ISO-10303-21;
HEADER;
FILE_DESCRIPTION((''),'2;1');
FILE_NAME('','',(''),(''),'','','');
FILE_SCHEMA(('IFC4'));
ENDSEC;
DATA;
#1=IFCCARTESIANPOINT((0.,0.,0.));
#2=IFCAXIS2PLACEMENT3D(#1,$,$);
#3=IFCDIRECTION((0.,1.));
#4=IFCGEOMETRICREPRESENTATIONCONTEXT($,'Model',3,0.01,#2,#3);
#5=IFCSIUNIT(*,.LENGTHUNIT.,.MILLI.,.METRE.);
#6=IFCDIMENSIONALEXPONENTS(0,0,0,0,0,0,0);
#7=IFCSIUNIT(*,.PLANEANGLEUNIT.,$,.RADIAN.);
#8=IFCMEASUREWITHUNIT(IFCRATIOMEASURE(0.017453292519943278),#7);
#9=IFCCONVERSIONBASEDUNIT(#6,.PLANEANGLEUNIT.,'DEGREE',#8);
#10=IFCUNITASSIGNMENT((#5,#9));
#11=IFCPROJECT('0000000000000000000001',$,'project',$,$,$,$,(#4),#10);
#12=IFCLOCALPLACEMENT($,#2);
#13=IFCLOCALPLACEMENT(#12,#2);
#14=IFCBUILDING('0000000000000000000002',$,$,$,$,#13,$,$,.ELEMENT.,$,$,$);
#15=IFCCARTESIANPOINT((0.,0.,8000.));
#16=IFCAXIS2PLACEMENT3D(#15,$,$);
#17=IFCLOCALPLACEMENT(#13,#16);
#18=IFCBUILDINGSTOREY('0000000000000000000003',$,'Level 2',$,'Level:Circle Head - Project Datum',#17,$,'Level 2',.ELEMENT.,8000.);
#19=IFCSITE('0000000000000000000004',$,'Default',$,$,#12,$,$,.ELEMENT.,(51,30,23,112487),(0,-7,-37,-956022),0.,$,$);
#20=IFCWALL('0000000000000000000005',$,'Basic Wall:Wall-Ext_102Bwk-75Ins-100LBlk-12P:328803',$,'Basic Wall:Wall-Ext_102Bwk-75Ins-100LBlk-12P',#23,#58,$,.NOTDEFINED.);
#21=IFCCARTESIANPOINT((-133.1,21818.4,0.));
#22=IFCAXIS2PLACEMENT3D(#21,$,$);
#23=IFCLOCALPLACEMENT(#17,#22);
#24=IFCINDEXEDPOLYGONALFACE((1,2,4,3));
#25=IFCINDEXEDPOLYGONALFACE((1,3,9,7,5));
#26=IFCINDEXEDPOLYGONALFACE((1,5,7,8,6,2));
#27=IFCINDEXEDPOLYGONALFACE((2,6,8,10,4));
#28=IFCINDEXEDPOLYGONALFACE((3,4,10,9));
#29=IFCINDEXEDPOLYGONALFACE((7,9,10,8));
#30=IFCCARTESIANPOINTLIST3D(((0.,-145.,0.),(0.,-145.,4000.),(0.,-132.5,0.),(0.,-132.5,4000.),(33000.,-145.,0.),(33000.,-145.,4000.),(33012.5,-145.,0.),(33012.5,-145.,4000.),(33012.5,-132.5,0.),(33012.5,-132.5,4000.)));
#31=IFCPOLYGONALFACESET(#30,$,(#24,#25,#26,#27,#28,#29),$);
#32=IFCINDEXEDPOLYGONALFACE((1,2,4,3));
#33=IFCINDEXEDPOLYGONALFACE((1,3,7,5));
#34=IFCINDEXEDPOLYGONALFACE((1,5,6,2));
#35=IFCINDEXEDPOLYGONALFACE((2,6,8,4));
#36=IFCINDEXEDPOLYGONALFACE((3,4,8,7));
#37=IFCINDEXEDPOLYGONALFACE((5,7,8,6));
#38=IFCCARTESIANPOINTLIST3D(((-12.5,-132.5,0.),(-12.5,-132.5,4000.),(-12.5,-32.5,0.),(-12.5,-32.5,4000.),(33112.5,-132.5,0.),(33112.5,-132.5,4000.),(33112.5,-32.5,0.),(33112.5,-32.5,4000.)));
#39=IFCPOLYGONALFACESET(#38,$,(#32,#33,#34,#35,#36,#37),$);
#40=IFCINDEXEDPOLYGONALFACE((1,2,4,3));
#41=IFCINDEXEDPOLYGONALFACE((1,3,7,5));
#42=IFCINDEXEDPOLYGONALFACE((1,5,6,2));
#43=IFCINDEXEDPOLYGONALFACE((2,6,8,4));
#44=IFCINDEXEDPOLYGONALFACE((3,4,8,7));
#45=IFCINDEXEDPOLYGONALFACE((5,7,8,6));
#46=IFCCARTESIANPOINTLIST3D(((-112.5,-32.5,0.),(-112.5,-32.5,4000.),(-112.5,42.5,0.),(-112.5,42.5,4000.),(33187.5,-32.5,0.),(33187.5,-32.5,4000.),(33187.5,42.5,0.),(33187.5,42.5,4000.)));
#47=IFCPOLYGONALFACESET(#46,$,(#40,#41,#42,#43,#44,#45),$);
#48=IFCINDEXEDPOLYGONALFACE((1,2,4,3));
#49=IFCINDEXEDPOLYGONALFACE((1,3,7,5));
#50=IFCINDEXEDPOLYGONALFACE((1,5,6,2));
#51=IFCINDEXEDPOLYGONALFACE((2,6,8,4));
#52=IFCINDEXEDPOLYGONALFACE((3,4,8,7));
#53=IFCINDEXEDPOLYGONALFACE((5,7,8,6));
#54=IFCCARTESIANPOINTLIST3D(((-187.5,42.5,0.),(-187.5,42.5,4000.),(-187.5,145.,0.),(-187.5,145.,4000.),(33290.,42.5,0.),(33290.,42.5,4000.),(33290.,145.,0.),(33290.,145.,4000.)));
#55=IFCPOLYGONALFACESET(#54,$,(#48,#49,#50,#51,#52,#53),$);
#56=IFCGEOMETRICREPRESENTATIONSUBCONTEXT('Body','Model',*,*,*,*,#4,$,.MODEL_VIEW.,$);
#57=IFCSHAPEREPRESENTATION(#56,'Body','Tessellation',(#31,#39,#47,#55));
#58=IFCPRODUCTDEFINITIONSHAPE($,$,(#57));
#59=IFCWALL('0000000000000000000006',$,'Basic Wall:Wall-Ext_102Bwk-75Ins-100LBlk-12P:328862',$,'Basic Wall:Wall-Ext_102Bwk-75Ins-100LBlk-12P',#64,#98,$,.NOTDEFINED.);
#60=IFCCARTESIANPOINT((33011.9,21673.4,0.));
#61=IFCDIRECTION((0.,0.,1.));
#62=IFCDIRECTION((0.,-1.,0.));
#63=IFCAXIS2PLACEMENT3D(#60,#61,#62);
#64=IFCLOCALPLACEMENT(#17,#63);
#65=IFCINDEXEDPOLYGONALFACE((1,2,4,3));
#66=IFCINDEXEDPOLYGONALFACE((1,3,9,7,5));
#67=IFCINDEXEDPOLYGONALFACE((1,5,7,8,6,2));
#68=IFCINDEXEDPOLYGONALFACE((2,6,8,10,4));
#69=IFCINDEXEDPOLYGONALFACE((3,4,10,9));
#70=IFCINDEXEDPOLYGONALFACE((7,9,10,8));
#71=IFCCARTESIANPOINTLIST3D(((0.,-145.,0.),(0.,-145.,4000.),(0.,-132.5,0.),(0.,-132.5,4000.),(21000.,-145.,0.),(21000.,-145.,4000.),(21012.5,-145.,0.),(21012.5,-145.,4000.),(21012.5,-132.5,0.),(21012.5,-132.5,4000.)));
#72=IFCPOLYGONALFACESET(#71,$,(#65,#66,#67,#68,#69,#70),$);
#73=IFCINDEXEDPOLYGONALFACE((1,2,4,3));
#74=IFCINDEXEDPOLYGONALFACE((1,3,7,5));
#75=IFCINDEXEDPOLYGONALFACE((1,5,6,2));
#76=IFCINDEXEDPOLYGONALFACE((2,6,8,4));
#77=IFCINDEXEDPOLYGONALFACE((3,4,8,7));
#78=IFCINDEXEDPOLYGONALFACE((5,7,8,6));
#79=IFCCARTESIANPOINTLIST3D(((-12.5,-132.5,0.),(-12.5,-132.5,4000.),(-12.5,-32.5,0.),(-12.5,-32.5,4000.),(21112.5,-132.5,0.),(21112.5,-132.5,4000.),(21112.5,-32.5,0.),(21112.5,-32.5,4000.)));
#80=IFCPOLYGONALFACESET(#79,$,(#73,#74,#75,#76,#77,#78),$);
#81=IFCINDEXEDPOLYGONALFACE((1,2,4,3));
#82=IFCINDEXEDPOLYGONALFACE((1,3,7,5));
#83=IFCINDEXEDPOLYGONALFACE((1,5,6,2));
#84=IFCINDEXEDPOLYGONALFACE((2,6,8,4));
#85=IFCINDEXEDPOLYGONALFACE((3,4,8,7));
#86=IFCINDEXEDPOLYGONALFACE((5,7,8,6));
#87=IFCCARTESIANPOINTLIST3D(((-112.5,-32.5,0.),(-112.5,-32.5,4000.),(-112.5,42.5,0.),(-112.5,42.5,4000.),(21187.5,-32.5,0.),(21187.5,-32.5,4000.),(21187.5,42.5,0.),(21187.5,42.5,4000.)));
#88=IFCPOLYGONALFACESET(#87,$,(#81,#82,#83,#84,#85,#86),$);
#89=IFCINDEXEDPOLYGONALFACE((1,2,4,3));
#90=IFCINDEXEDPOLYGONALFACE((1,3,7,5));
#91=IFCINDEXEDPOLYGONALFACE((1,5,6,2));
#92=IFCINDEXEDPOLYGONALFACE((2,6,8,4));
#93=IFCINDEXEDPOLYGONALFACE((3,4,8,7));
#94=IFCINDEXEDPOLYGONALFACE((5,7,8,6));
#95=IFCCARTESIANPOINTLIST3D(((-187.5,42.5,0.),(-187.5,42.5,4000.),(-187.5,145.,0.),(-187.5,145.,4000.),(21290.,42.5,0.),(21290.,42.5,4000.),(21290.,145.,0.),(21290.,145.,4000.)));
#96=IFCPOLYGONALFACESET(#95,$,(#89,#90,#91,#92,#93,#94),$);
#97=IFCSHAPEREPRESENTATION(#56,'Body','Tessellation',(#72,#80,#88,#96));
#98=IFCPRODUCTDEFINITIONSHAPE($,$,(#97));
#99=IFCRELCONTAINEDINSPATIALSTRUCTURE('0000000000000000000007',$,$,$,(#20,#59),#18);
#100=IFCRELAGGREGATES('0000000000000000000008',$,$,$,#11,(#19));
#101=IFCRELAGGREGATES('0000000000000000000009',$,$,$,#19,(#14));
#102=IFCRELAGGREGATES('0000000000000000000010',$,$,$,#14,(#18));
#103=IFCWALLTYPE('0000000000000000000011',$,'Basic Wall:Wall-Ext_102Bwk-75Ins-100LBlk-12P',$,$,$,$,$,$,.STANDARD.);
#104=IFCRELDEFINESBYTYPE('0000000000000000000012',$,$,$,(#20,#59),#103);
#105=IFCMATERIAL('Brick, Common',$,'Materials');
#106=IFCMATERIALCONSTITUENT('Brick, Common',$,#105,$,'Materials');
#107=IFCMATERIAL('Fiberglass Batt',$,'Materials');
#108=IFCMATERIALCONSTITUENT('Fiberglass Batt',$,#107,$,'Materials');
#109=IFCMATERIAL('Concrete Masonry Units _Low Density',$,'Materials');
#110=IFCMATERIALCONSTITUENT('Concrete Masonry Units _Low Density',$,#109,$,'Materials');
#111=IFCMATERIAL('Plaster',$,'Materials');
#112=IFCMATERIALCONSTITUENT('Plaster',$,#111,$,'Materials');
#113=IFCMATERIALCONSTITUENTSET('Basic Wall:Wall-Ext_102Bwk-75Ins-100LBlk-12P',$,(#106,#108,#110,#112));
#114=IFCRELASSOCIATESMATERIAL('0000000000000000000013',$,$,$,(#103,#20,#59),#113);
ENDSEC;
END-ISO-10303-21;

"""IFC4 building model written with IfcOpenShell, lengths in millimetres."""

from ifc_helpers import new_model, entity, si_unit, converted_unit, direction, frame, origin, place, context, subcontext, project, spatial, indexed_curve, outline, extrude, material, constituent, constituent_set, type_object, element, save


model = new_model("IFC4")

# Units and contexts
model_context = context("Model", 3, precision=0.01, world=origin(), true_north=direction((0.0, 1.0)))
body_context = subcontext(model_context, "Body", "Model", "MODEL_VIEW")
ifc_project = project(units=[si_unit("LENGTHUNIT", "METRE", prefix="MILLI"), converted_unit("PLANEANGLEUNIT", "DEGREE", entity("IfcRatioMeasure", 0.017453292519943278), si_unit("PLANEANGLEUNIT", "RADIAN"), dimensions=[0, 0, 0, 0, 0, 0, 0])], contexts=[model_context])

# Site, building, storey
site_placement = place(None, origin())
site = spatial("IfcSite", under=ifc_project, at=site_placement, Name="Default", CompositionType="ELEMENT", RefLatitude=(51, 30, 23, 112487), RefLongitude=(0, -7, -37, -956022), RefElevation=0.0)
building_placement = place(site_placement, origin())
building = spatial("IfcBuilding", under=site, at=building_placement, CompositionType="ELEMENT")
storey_placement = place(building_placement, frame((0.0, 0.0, 8000.0)))
storey = spatial("IfcBuildingStorey", under=building, at=storey_placement, Name="Level 2", ObjectType="Level:Circle Head - Project Datum", LongName="Level 2", CompositionType="ELEMENT", Elevation=8000.0)

# Walls
ifc_material_1 = material(Name="Brick, Common", Category="Materials")
ifc_constituent_1 = constituent(ifc_material_1, Name="Brick, Common", Category="Materials")
ifc_material_2 = material(Name="Fiberglass Batt", Category="Materials")
ifc_constituent_2 = constituent(ifc_material_2, Name="Fiberglass Batt", Category="Materials")
ifc_material_3 = material(Name="Concrete Masonry Units _Low Density", Category="Materials")
ifc_constituent_3 = constituent(ifc_material_3, Name="Concrete Masonry Units _Low Density", Category="Materials")
ifc_material_4 = material(Name="Plaster", Category="Materials")
ifc_constituent_4 = constituent(ifc_material_4, Name="Plaster", Category="Materials")
ifc_constituent_set_1 = constituent_set(constituents=[ifc_constituent_1, ifc_constituent_2, ifc_constituent_3, ifc_constituent_4], Name="Basic Wall:Wall-Ext_102Bwk-75Ins-100LBlk-12P")
wall_type = type_object("IfcWallType", Name="Basic Wall:Wall-Ext_102Bwk-75Ins-100LBlk-12P", PredefinedType="STANDARD", material=ifc_constituent_set_1)
wall_1_placement = place(storey_placement, frame((-133.1, 21818.4, 0.0)))
element("IfcWall", 1, at=wall_1_placement, inside=storey, type_object=wall_type, material=ifc_constituent_set_1, Name="Basic Wall:Wall-Ext_102Bwk-75Ins-100LBlk-12P:328803", ObjectType="Basic Wall:Wall-Ext_102Bwk-75Ins-100LBlk-12P", PredefinedType="NOTDEFINED", context=body_context, shape_type="SweptSolid", body=[
    extrude(outline(indexed_curve([(13195.0, -5.0), (13207.5, -5.0), (13207.5, 7.5), (-19805.0, 7.5), (-19805.0, -5.0), (13195.0, -5.0)], self_intersect=False)), frame((19805.0, -140.0, 0.0)), (0.0, 0.0, 1.0), 4000.0),
    extrude(outline(indexed_curve([(-16562.5, -50.0), (16562.5, -50.0), (16562.5, 50.0), (-16562.5, 50.0), (-16562.5, -50.0)], self_intersect=False)), frame((16550.0, -82.5, 0.0)), (0.0, 0.0, 1.0), 4000.0),
    extrude(outline(indexed_curve([(-16650.0, -37.5), (16650.0, -37.5), (16650.0, 37.5), (-16650.0, 37.5), (-16650.0, -37.5)], self_intersect=False)), frame((16537.5, 5.0, 0.0)), (0.0, 0.0, 1.0), 4000.0),
    extrude(outline(indexed_curve([(-51.2, -16738.8), (51.3, -16738.8), (51.2, 16738.8), (-51.3, 16738.8), (-51.2, -16738.8)], self_intersect=False)), frame((16551.2, 93.8, 0.0), z_axis=(0.0, 0.0, 1.0), x_axis=(0.0, -1.0, 0.0)), (0.0, 0.0, 1.0), 4000.0),
])
wall_2_placement = place(storey_placement, frame((33011.9, 21673.4, 0.0), z_axis=(0.0, 0.0, 1.0), x_axis=(0.0, -1.0, 0.0)))
element("IfcWall", 2, at=wall_2_placement, inside=storey, type_object=wall_type, material=ifc_constituent_set_1, Name="Basic Wall:Wall-Ext_102Bwk-75Ins-100LBlk-12P:328862", ObjectType="Basic Wall:Wall-Ext_102Bwk-75Ins-100LBlk-12P", PredefinedType="NOTDEFINED", context=body_context, shape_type="SweptSolid", body=[
    extrude(outline(indexed_curve([(8395.0, -5.0), (8407.5, -5.0), (8407.5, 7.5), (-12605.0, 7.5), (-12605.0, -5.0), (8395.0, -5.0)], self_intersect=False)), frame((12605.0, -140.0, 0.0)), (0.0, 0.0, 1.0), 4000.0),
    extrude(outline(indexed_curve([(-10562.5, -50.0), (10562.5, -50.0), (10562.5, 50.0), (-10562.5, 50.0), (-10562.5, -50.0)], self_intersect=False)), frame((10550.0, -82.5, 0.0)), (0.0, 0.0, 1.0), 4000.0),
    extrude(outline(indexed_curve([(-10650.0, -37.5), (10650.0, -37.5), (10650.0, 37.5), (-10650.0, 37.5), (-10650.0, -37.5)], self_intersect=False)), frame((10537.5, 5.0, 0.0)), (0.0, 0.0, 1.0), 4000.0),
    extrude(outline(indexed_curve([(-51.3, -10738.8), (51.2, -10738.8), (51.3, 10738.8), (-51.2, 10738.8), (-51.3, -10738.8)], self_intersect=False)), frame((10551.3, 93.7, 0.0), z_axis=(0.0, 0.0, 1.0), x_axis=(0.0, -1.0, 0.0)), (0.0, 0.0, 1.0), 4000.0),
])

save(model, "model.ifc")
